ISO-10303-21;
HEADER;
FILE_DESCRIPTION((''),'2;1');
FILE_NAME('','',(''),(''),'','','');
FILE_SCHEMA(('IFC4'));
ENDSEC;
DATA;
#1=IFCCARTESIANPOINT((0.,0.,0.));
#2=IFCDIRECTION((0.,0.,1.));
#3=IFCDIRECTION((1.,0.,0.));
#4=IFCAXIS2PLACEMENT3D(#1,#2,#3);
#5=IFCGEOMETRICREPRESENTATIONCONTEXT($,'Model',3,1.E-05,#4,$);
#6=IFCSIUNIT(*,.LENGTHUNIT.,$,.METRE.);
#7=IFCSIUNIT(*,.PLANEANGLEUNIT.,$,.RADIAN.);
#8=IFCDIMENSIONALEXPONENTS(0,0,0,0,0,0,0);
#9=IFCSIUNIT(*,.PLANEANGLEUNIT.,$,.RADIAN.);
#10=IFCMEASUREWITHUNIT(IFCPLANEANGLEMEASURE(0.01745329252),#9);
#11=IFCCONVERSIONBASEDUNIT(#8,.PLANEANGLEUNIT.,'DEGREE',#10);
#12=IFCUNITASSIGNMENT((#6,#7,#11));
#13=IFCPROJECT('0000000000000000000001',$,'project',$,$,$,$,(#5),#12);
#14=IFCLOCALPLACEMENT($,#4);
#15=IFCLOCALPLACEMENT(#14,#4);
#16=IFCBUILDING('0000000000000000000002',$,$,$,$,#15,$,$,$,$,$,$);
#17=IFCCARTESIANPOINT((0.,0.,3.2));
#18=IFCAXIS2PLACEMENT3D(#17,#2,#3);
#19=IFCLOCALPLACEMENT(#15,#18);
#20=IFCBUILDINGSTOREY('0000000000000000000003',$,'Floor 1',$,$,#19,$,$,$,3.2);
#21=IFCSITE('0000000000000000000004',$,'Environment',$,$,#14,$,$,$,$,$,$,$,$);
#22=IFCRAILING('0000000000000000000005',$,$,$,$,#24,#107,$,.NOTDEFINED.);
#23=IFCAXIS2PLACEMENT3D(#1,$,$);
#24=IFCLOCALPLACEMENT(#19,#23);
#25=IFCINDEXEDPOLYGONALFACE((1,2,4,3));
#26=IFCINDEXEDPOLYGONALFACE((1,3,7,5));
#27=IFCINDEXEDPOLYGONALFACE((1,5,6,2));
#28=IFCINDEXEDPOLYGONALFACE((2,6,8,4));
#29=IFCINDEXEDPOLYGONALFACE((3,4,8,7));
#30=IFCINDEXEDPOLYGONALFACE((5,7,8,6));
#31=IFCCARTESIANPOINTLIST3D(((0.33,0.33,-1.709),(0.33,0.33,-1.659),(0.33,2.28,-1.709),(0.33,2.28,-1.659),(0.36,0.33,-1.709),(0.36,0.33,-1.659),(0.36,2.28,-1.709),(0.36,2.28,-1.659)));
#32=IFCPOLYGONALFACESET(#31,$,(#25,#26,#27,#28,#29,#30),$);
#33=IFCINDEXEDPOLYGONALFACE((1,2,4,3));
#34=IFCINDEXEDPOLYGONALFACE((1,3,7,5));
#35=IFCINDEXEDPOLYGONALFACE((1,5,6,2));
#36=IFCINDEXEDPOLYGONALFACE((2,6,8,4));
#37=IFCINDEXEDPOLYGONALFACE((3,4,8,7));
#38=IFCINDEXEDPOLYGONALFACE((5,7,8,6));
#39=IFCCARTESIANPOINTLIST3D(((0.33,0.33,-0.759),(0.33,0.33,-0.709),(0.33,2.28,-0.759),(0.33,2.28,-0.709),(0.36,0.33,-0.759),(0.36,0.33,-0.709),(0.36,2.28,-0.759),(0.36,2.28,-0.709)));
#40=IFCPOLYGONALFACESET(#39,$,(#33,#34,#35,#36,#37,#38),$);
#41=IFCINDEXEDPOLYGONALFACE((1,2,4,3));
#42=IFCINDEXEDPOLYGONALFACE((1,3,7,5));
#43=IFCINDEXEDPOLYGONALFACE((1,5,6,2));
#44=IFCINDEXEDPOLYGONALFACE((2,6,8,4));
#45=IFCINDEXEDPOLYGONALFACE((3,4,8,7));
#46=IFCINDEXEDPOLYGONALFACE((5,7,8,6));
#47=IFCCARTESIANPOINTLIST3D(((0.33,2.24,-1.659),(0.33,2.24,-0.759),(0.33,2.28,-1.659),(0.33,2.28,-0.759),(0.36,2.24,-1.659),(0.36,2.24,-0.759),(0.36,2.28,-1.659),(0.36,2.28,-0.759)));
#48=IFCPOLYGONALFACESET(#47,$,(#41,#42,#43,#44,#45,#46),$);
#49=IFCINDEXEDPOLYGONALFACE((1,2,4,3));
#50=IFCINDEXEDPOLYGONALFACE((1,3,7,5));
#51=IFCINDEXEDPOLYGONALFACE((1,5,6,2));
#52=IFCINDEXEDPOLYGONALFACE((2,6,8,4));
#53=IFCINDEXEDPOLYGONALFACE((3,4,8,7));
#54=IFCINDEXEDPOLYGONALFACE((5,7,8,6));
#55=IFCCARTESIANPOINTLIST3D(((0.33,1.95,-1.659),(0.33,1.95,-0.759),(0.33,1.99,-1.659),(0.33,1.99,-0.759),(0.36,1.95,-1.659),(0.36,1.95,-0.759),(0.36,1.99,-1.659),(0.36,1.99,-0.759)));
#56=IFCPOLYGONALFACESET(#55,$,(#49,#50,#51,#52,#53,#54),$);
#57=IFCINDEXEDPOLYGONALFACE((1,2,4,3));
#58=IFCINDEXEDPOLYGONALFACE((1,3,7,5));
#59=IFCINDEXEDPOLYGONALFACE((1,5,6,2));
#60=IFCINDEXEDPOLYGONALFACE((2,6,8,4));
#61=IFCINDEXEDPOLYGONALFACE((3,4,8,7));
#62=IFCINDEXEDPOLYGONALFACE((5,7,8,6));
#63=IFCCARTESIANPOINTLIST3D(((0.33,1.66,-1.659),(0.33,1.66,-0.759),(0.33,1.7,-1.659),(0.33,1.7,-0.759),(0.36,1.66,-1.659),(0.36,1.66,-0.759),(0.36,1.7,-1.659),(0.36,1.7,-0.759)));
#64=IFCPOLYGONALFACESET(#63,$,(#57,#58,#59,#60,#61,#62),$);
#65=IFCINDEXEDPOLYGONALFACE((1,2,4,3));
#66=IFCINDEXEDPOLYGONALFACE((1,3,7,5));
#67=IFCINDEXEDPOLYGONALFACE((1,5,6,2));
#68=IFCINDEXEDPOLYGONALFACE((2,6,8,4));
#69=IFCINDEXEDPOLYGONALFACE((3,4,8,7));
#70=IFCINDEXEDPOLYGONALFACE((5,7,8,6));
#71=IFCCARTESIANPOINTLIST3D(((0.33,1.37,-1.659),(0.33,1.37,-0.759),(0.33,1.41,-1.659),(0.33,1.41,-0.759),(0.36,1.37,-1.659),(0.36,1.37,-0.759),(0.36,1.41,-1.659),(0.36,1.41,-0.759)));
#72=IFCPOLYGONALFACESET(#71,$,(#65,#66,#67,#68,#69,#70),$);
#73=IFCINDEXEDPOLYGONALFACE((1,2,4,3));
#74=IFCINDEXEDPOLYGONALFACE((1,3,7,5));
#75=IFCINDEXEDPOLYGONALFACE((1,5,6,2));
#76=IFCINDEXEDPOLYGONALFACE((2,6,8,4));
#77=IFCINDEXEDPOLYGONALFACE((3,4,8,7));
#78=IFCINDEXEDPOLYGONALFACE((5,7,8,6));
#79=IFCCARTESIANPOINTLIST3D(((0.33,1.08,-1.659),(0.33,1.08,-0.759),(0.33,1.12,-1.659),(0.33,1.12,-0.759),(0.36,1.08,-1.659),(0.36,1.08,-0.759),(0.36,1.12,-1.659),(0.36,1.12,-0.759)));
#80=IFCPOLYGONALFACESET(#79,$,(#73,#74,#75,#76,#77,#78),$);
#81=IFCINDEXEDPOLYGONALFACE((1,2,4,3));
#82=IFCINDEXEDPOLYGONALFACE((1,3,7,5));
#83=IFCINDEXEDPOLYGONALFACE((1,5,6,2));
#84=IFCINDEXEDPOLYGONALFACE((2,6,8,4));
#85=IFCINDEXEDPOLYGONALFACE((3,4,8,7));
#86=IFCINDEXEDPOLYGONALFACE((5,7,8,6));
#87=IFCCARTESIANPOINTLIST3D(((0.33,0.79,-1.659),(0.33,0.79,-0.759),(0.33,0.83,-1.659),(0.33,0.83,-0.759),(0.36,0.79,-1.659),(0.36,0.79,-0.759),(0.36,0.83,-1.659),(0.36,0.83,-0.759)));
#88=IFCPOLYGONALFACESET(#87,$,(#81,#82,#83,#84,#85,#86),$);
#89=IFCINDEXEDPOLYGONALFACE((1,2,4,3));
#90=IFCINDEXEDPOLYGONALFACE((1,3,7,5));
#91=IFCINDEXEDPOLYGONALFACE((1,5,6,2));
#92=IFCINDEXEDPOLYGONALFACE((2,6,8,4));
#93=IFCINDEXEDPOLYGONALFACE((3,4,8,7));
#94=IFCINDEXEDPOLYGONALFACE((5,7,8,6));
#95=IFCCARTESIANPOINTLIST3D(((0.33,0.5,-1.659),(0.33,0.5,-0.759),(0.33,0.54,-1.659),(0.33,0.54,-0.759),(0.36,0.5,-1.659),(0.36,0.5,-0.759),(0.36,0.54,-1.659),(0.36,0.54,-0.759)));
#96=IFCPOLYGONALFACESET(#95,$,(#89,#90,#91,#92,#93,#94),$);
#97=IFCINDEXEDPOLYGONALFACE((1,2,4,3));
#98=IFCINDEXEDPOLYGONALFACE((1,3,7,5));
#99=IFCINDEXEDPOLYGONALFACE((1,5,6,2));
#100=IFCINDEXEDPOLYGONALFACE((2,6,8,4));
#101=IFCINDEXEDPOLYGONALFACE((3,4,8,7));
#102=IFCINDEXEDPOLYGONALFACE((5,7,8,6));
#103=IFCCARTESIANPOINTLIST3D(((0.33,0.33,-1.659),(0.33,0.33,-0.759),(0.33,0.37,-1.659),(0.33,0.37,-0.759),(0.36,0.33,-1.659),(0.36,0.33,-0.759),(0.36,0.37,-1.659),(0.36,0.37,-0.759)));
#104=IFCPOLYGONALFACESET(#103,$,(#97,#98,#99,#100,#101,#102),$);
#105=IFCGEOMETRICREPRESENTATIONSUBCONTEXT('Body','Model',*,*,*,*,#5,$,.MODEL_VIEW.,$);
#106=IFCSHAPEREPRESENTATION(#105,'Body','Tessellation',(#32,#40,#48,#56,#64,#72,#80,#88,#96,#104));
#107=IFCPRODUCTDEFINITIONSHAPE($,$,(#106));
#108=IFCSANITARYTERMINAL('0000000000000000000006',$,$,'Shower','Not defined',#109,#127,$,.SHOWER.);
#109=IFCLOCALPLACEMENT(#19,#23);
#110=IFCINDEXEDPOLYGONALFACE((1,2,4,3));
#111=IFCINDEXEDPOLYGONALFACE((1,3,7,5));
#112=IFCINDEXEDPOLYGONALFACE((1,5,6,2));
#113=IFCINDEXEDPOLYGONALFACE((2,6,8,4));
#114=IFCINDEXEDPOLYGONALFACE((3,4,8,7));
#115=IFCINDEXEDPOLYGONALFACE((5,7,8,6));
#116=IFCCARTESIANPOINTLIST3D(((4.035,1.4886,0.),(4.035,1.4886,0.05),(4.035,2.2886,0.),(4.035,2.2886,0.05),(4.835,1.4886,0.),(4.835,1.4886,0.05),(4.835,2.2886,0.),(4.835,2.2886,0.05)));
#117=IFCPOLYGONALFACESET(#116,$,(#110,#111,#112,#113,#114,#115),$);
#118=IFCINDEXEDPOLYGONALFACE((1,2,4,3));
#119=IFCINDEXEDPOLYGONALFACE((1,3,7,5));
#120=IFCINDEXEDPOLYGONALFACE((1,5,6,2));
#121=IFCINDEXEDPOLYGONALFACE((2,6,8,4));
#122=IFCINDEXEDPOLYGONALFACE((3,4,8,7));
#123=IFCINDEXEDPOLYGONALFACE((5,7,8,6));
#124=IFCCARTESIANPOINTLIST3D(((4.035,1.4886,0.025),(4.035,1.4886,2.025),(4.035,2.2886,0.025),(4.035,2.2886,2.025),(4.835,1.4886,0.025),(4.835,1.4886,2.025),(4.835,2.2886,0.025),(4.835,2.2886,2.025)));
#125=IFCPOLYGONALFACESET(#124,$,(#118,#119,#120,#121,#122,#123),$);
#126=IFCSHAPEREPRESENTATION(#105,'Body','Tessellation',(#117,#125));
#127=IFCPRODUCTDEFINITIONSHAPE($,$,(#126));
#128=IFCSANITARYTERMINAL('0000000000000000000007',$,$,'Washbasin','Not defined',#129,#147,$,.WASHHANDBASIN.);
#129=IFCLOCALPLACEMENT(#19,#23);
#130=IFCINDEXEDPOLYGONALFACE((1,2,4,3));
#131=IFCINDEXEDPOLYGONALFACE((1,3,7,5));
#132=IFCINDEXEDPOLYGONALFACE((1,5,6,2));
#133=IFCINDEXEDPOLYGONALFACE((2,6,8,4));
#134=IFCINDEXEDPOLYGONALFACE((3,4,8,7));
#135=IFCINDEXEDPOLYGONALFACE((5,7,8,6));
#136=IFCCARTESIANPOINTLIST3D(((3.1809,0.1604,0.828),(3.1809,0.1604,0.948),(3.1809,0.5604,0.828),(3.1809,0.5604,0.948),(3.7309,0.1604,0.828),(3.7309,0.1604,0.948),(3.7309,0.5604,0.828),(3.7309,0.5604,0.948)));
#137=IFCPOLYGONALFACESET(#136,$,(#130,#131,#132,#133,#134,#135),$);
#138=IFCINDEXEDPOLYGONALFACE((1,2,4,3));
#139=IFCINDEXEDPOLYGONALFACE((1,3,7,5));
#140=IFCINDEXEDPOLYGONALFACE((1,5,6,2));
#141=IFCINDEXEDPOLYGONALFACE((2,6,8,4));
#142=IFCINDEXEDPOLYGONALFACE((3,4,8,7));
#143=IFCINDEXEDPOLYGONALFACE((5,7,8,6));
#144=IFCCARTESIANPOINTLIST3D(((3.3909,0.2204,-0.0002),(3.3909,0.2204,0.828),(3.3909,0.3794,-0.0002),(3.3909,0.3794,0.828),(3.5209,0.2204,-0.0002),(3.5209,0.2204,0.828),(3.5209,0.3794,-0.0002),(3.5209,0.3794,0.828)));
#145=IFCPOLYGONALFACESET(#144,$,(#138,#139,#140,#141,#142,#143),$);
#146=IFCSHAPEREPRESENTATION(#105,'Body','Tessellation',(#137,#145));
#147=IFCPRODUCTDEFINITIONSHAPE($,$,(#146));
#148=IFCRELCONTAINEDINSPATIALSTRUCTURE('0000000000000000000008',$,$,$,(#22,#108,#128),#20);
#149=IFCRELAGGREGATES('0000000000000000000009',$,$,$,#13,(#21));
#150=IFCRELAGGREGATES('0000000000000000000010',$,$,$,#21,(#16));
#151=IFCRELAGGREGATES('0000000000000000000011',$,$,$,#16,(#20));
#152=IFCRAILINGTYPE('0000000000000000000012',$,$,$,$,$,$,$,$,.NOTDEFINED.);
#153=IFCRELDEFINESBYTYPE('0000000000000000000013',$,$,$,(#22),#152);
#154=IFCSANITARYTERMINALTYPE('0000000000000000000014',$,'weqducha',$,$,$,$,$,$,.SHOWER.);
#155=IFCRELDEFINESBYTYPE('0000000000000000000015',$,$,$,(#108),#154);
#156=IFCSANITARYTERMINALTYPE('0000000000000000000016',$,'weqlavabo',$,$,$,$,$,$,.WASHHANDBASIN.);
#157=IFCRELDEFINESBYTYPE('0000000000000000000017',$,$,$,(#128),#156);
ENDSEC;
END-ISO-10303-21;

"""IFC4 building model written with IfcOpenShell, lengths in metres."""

from ifc_helpers import new_model, entity, si_unit, converted_unit, frame, origin_with_axes, place, context, subcontext, project, spatial, polyline, outline, extrude, source, transform, mapped, type_object, element, save


model = new_model("IFC4")

# Units and contexts
model_context = context("Model", 3, precision=1e-05, world=origin_with_axes())
body_context = subcontext(model_context, "Body", "Model", "MODEL_VIEW")
ifc_project = project(units=[si_unit("LENGTHUNIT", "METRE"), si_unit("PLANEANGLEUNIT", "RADIAN"), converted_unit("PLANEANGLEUNIT", "DEGREE", entity("IfcPlaneAngleMeasure", 0.01745329252), si_unit("PLANEANGLEUNIT", "RADIAN"), dimensions=[0, 0, 0, 0, 0, 0, 0])], contexts=[model_context])

# Site, building, storey
site_placement = place(None, origin_with_axes())
site = spatial("IfcSite", under=ifc_project, at=site_placement, Name="Environment")
building_placement = place(site_placement, origin_with_axes())
building = spatial("IfcBuilding", under=site, at=building_placement)
storey_placement = place(building_placement, frame((0.0, 0.0, 3.2), z_axis=(0.0, 0.0, 1.0), x_axis=(1.0, 0.0, 0.0)))
storey = spatial("IfcBuildingStorey", under=building, at=storey_placement, Name="Floor 1", Elevation=3.2)

# Railing
railing_type = type_object("IfcRailingType", PredefinedType="NOTDEFINED")
railing_1_placement = place(storey_placement, frame((0.33, 2.28, -1.709), z_axis=(0.0, 0.0, 1.0), x_axis=(0.0, -1.0, 0.0)))
element("IfcRailing", 1, at=railing_1_placement, inside=storey, type_object=railing_type, PredefinedType="NOTDEFINED", context=body_context, shape_type="MappedRepresentation", body=[
    extrude(outline(polyline([(0.0, 0.0), (1.95, 0.0), (1.95, 0.05), (0.0, 0.05), (0.0, 0.0)])), frame((0.0, 0.03, 0.0), z_axis=(0.0, -1.0, 0.0), x_axis=(1.0, 0.0, 0.0)), (0.0, 0.0, 1.0), 0.03),
    extrude(outline(polyline([(0.0, 0.0), (1.95, 0.0), (1.95, 0.05), (0.0, 0.05), (0.0, 0.0)])), frame((0.0, 0.03, 0.95), z_axis=(0.0, -1.0, 0.0), x_axis=(1.0, 0.0, 0.0)), (0.0, 0.0, 1.0), 0.03),
    extrude(outline(polyline([(0.0, 0.0), (0.04, 0.0), (0.04, 0.9), (0.0, 0.9), (0.0, 0.0)])), frame((0.0, 0.03, 0.05), z_axis=(0.0, -1.0, 0.0), x_axis=(1.0, 0.0, 0.0)), (0.0, 0.0, 1.0), 0.03),
    extrude(outline(polyline([(0.0, 0.0), (0.04, 0.0), (0.04, 0.9), (0.0, 0.9), (0.0, 0.0)])), frame((0.29, 0.03, 0.05), z_axis=(0.0, -1.0, 0.0), x_axis=(1.0, 0.0, 0.0)), (0.0, 0.0, 1.0), 0.03),
    extrude(outline(polyline([(0.0, 0.0), (0.04, 0.0), (0.04, 0.9), (0.0, 0.9), (0.0, 0.0)])), frame((0.58, 0.03, 0.05), z_axis=(0.0, -1.0, 0.0), x_axis=(1.0, 0.0, 0.0)), (0.0, 0.0, 1.0), 0.03),
    extrude(outline(polyline([(0.0, 0.0), (0.04, 0.0), (0.04, 0.9), (0.0, 0.9), (0.0, 0.0)])), frame((0.87, 0.03, 0.05), z_axis=(0.0, -1.0, 0.0), x_axis=(1.0, 0.0, 0.0)), (0.0, 0.0, 1.0), 0.03),
    extrude(outline(polyline([(0.0, 0.0), (0.04, 0.0), (0.04, 0.9), (0.0, 0.9), (0.0, 0.0)])), frame((1.16, 0.03, 0.05), z_axis=(0.0, -1.0, 0.0), x_axis=(1.0, 0.0, 0.0)), (0.0, 0.0, 1.0), 0.03),
    extrude(outline(polyline([(0.0, 0.0), (0.04, 0.0), (0.04, 0.9), (0.0, 0.9), (0.0, 0.0)])), frame((1.45, 0.03, 0.05), z_axis=(0.0, -1.0, 0.0), x_axis=(1.0, 0.0, 0.0)), (0.0, 0.0, 1.0), 0.03),
    extrude(outline(polyline([(0.0, 0.0), (0.04, 0.0), (0.04, 0.9), (0.0, 0.9), (0.0, 0.0)])), frame((1.74, 0.03, 0.05), z_axis=(0.0, -1.0, 0.0), x_axis=(1.0, 0.0, 0.0)), (0.0, 0.0, 1.0), 0.03),
    extrude(outline(polyline([(0.0, 0.0), (0.04, 0.0), (0.04, 0.9), (0.0, 0.9), (0.0, 0.0)])), frame((1.91, 0.03, 0.05), z_axis=(0.0, -1.0, 0.0), x_axis=(1.0, 0.0, 0.0)), (0.0, 0.0, 1.0), 0.03),
])

# Sanitary terminals
sanitary_terminal_type_1 = type_object("IfcSanitaryTerminalType", Name="weqducha", PredefinedType="SHOWER")
shared_shape_1 = source(origin_with_axes(), body_context, "Body", "SolidModel", [
    extrude(outline(polyline([(0.0, -0.4), (0.8, -0.4), (0.8, 0.4), (0.0, 0.4), (0.0, -0.4)])), frame((0.0, 0.0, -0.025), z_axis=(0.0, 0.0, 1.0), x_axis=(1.0, 0.0, 0.0)), (0.0, 0.0, 1.0), 0.05),
    extrude(outline(polyline([(-0.4, -0.4), (0.4, -0.4), (0.4, 0.4), (-0.4, 0.4), (-0.4, -0.4)])), frame((0.4, 0.0, 0.0), z_axis=(0.0, 0.0, 1.0), x_axis=(1.0, 0.0, 0.0)), (0.0, 0.0, 1.0), 2.0),
])
sanitary_terminal_1_placement = place(storey_placement, frame((4.435, 2.2886, 0.025), z_axis=(0.0, 0.0, 1.0), x_axis=(0.0, -1.0, 0.0)))
element("IfcSanitaryTerminal", 2, at=sanitary_terminal_1_placement, inside=storey, type_object=sanitary_terminal_type_1, Description="Shower", ObjectType="Not defined", PredefinedType="SHOWER", context=body_context, shape_type="MappedRepresentation", body=[
    mapped(shared_shape_1, transform((0.0, 0.0, 0.0), x_axis=(1.0, 0.0, 0.0), y_axis=(0.0, 1.0, 0.0), z_axis=(0.0, 0.0, 1.0))),
])
sanitary_terminal_type_2 = type_object("IfcSanitaryTerminalType", Name="weqlavabo", PredefinedType="WASHHANDBASIN")
shared_shape_2 = source(origin_with_axes(), body_context, "Body", "SolidModel", [
    extrude(outline(polyline([(0.0, -0.275), (0.4, -0.275), (0.4, 0.275), (0.0, 0.275), (0.0, -0.275)])), frame((0.0, 0.0, -0.12), z_axis=(0.0, 0.0, 1.0), x_axis=(1.0, 0.0, 0.0)), (0.0, 0.0, 1.0), 0.12),
    extrude(outline(polyline([(0.0, -0.065), (0.159, -0.065), (0.159, 0.065), (0.0, 0.065), (0.0, -0.065)])), frame((0.06, 0.0, -0.9482), z_axis=(0.0, 0.0, 1.0), x_axis=(1.0, 0.0, 0.0)), (0.0, 0.0, 1.0), 0.8282),
])
sanitary_terminal_2_placement = place(storey_placement, frame((3.4559, 0.1604, 0.948), z_axis=(0.0, 0.0, 1.0), x_axis=(0.0, 1.0, 0.0)))
element("IfcSanitaryTerminal", 3, at=sanitary_terminal_2_placement, inside=storey, type_object=sanitary_terminal_type_2, Description="Washbasin", ObjectType="Not defined", PredefinedType="WASHHANDBASIN", context=body_context, shape_type="MappedRepresentation", body=[
    mapped(shared_shape_2, transform((0.0, 0.0, 0.0), x_axis=(1.0, 0.0, 0.0), y_axis=(0.0, 1.0, 0.0), z_axis=(0.0, 0.0, 1.0))),
])

save(model, "model.ifc")
